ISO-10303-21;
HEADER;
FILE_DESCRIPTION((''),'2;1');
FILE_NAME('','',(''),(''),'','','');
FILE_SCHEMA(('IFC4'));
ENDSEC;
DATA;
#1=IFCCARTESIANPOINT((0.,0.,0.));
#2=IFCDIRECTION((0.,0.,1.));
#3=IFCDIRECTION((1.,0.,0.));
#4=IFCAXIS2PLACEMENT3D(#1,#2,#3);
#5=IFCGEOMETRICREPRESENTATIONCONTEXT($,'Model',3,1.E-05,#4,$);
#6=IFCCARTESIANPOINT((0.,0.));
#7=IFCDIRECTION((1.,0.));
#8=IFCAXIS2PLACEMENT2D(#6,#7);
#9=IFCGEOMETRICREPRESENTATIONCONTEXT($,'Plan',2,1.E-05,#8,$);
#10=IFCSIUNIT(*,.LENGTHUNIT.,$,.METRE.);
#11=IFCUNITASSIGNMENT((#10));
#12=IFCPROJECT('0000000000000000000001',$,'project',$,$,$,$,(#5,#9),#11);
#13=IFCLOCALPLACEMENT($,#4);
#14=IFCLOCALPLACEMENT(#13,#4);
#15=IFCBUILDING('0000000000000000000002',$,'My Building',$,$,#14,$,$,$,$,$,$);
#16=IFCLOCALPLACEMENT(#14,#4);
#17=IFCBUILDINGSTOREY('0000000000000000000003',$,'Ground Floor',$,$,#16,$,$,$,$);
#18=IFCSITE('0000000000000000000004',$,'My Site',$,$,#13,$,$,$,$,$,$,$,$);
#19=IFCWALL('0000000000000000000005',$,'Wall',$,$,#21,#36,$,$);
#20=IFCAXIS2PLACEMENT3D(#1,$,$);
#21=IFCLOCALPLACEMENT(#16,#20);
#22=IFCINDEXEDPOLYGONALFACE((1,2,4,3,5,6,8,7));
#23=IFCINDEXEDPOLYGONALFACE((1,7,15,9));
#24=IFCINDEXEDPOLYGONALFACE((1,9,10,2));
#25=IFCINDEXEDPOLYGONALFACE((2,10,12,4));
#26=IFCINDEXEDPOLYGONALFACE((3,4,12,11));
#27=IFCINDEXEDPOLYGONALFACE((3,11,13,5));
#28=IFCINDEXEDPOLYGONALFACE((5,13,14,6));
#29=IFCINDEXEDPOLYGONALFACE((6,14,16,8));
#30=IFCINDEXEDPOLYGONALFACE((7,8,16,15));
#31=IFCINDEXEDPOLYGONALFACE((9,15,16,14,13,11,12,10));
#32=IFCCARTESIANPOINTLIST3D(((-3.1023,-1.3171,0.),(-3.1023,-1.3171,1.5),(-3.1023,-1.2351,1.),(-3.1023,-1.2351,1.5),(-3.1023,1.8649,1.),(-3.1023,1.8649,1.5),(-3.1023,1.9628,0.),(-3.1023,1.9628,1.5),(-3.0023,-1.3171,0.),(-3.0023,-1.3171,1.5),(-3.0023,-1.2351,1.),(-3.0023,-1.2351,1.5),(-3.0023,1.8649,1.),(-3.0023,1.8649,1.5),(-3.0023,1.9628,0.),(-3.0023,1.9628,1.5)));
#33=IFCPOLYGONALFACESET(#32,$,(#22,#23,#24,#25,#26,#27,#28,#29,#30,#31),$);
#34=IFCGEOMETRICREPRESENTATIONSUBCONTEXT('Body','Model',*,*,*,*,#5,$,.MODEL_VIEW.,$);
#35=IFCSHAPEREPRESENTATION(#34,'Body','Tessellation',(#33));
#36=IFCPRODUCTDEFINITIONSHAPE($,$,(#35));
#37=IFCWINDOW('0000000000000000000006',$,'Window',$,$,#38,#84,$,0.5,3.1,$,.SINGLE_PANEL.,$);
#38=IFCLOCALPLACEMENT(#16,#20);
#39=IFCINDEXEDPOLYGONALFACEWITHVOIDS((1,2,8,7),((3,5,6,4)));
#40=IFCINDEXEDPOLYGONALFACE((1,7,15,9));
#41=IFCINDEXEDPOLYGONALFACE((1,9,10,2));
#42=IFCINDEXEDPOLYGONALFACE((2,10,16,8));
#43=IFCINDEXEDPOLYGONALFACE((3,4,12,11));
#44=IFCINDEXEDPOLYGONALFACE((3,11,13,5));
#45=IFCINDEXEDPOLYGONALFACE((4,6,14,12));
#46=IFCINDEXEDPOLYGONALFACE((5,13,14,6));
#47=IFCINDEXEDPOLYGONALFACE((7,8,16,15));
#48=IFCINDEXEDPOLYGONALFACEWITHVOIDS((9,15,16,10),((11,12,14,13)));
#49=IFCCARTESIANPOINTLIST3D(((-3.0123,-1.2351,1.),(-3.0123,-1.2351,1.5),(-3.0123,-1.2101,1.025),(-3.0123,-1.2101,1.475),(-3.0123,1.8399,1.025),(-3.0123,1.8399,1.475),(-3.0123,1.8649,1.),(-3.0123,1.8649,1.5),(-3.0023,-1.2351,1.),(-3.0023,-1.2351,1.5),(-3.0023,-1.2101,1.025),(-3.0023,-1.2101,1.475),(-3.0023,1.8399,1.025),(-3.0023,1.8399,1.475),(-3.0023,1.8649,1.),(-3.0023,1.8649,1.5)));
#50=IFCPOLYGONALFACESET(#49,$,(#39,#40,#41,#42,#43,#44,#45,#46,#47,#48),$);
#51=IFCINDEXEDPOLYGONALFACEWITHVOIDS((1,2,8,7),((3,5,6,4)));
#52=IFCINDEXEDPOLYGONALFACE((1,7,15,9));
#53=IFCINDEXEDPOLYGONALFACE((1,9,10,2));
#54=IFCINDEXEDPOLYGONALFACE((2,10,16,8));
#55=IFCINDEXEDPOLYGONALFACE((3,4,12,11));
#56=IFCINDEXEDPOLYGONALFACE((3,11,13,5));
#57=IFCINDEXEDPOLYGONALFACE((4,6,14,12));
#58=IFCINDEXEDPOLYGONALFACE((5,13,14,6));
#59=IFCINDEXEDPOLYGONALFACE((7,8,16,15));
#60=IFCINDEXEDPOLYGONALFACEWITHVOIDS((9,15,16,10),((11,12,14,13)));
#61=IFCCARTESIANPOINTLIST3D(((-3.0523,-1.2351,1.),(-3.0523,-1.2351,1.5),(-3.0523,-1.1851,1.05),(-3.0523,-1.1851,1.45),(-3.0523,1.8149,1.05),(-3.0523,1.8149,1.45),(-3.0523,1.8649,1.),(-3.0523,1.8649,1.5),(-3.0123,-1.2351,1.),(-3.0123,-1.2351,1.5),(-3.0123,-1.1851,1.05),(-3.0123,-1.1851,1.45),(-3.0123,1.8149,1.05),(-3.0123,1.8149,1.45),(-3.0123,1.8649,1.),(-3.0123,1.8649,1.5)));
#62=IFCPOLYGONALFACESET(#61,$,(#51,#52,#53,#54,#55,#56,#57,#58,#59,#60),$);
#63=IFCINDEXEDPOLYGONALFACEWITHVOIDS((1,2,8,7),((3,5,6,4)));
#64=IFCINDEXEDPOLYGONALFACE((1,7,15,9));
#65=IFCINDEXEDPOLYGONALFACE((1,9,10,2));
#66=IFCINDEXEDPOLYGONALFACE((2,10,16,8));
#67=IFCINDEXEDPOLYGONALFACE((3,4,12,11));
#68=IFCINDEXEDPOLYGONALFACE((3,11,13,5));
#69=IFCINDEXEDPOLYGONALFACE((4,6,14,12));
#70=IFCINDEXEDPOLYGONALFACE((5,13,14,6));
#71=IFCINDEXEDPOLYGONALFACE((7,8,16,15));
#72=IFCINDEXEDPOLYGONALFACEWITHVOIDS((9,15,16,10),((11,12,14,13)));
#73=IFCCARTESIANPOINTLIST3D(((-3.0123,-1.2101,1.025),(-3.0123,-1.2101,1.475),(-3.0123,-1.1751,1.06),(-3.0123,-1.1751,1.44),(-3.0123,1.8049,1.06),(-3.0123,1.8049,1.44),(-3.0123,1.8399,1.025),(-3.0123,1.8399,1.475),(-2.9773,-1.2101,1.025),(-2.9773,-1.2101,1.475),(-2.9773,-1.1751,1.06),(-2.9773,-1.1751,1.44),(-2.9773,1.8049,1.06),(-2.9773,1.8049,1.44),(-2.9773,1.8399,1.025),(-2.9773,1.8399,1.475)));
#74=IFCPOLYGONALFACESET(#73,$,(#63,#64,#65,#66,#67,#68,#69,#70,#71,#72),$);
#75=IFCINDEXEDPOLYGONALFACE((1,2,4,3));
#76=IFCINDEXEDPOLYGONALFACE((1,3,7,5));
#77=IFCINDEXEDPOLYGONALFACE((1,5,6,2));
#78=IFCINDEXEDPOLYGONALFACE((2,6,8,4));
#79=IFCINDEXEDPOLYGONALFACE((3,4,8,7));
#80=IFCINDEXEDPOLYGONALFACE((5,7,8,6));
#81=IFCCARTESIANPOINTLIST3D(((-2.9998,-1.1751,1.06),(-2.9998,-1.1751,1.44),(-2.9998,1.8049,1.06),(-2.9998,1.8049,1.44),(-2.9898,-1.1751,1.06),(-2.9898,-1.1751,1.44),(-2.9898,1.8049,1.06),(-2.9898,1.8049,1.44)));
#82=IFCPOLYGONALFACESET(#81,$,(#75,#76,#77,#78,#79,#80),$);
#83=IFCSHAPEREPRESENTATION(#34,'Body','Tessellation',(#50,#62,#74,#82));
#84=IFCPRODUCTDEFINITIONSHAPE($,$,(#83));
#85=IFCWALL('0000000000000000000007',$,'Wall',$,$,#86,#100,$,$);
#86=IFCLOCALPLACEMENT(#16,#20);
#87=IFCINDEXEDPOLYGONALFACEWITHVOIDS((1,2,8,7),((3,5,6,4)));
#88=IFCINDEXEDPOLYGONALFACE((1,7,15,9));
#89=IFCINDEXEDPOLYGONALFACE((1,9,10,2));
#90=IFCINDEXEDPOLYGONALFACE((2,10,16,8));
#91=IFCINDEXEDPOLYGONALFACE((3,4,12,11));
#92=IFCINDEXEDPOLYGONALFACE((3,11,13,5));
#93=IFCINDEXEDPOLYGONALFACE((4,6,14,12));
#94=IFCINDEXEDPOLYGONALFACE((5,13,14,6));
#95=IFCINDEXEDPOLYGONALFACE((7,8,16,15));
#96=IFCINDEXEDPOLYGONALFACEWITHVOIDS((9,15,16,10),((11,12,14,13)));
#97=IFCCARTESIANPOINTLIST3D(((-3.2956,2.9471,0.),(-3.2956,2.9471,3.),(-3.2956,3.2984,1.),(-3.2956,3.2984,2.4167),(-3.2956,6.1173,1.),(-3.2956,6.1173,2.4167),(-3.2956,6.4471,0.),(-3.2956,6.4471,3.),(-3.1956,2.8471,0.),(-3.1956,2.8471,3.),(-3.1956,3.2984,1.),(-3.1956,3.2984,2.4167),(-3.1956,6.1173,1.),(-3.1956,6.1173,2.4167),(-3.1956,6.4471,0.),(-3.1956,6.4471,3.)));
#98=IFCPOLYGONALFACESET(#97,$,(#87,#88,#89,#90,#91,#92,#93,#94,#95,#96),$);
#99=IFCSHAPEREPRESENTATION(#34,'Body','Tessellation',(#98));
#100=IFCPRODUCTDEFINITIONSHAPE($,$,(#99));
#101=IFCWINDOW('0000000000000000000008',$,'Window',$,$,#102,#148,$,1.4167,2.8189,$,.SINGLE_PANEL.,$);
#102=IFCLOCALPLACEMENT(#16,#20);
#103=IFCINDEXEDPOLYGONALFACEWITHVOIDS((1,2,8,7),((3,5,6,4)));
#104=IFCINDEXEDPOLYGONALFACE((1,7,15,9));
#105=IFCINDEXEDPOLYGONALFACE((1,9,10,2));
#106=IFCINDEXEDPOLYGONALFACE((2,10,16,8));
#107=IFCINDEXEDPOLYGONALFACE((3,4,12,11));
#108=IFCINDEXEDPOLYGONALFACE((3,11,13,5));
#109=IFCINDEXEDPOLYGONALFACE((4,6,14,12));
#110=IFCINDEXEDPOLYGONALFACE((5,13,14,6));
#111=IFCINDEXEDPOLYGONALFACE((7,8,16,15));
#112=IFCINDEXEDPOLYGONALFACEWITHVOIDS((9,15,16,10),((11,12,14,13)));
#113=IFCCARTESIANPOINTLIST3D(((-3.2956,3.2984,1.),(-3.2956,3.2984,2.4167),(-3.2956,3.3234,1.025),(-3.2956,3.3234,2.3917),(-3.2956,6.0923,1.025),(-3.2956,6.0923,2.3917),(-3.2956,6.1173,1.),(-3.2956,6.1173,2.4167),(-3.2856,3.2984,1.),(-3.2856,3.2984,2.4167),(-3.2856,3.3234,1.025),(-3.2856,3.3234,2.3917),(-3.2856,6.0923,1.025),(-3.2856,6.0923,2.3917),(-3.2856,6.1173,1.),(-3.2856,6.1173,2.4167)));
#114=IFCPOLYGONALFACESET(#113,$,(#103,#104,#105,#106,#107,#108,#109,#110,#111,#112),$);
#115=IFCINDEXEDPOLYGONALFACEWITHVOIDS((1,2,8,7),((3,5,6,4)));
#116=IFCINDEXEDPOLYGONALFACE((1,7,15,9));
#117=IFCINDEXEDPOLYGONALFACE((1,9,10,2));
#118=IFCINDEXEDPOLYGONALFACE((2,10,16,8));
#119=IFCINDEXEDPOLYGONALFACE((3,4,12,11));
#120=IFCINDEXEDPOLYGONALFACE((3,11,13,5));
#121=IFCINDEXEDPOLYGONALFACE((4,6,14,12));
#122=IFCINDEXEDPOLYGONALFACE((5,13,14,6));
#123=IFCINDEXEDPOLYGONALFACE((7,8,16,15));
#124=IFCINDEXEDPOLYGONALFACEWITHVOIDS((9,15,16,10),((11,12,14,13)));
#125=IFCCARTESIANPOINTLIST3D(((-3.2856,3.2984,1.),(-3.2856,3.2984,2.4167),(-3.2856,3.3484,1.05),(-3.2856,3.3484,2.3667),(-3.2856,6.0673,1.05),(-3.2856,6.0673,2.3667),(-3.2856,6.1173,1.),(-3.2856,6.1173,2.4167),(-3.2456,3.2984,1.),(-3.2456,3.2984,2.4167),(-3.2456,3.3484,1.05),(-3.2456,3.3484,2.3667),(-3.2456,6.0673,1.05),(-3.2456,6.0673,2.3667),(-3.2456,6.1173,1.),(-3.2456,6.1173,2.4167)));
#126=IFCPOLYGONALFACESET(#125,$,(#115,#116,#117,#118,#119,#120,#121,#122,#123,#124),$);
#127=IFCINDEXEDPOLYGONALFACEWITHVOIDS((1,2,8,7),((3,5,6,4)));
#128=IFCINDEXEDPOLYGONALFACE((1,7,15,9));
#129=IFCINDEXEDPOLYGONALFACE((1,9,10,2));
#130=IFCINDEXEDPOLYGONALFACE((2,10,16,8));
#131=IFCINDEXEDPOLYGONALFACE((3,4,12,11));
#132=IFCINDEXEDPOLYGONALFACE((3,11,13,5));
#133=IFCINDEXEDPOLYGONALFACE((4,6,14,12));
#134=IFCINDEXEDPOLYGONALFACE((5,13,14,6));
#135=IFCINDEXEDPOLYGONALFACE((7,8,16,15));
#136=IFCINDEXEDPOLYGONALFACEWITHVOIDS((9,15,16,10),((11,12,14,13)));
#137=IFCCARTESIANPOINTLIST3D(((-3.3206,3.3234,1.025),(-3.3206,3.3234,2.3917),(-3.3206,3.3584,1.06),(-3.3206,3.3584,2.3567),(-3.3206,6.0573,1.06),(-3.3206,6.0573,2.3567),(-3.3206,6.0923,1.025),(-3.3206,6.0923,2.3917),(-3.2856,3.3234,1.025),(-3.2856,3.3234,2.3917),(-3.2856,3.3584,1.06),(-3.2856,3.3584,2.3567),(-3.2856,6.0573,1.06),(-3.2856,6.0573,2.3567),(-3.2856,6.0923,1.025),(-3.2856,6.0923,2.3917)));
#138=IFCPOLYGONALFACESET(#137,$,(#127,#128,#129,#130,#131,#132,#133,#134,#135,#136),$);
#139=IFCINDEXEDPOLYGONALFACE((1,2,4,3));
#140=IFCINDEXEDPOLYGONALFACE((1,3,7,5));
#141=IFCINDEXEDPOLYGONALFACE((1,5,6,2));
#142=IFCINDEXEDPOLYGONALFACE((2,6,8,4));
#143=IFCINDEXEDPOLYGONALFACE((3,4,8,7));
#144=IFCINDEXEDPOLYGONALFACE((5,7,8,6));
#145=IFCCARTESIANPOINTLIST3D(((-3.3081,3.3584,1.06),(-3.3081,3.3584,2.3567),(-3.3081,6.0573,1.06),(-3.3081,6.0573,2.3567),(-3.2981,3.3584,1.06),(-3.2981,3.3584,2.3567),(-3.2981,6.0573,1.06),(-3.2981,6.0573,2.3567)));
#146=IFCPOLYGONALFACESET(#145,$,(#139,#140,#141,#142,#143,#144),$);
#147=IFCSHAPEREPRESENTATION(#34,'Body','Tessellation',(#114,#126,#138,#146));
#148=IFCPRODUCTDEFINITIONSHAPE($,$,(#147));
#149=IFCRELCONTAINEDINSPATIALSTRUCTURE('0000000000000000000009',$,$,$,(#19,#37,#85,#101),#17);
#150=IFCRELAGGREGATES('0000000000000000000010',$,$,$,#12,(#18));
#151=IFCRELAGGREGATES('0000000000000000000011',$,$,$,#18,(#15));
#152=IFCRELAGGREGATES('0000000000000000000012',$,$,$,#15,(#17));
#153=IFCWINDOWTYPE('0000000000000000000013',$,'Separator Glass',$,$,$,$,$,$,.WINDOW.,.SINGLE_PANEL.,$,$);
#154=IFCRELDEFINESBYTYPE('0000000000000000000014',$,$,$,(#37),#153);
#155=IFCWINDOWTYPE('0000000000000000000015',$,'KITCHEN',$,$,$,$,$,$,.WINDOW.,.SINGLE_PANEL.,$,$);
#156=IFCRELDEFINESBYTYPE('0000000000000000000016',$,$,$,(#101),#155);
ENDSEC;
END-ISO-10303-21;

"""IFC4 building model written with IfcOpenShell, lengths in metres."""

from ifc_helpers import new_model, entity, si_unit, frame, origin_with_axes, origin_2d_with_axis, place, context, subcontext, project, spatial, line, indexed_curve, outline, extrude, shape, source, transform, mapped, type_object, type_shapes, element, fill, save


model = new_model("IFC4")

# Units and contexts
model_context = context("Model", 3, precision=1e-05, world=origin_with_axes())
plan_context = context("Plan", 2, precision=1e-05, world=origin_2d_with_axis())
body_context_1 = subcontext(model_context, "Body", "Model", "MODEL_VIEW")
body_context_2 = subcontext(plan_context, "Body", "Plan", "PLAN_VIEW")
ifc_project = project(units=[si_unit("LENGTHUNIT", "METRE")], contexts=[model_context, plan_context])

# Site, building, storey
site_placement = place(None, origin_with_axes())
site = spatial("IfcSite", under=ifc_project, at=site_placement, Name="My Site")
building_placement = place(site_placement, origin_with_axes())
building = spatial("IfcBuilding", under=site, at=building_placement, Name="My Building")
storey_placement = place(building_placement, origin_with_axes())
storey = spatial("IfcBuildingStorey", under=building, at=storey_placement, Name="Ground Floor")

# Walls, openings, windows
wall_1_placement = place(storey_placement, frame((-3.0023, -1.3171, 0.0), z_axis=(0.0, 0.0, 1.0), x_axis=(0.0, 1.0, 0.0)))
wall_1 = element("IfcWall", 1, at=wall_1_placement, inside=storey, Name="Wall", context=body_context_1, shape_type="SweptSolid", body=[
    extrude(outline(indexed_curve([(0.0, 0.0), (0.0, 0.1), (3.2798, 0.1), (3.2798, 0.0)], segments=[line(1, 2, 3, 4, 1)])), origin_with_axes(), (0.0, 0.0, 1.0), 1.5),
])
shared_shape_1 = source(origin_with_axes(), body_context_1, "Body", "SweptSolid", [
    extrude(outline(indexed_curve([(0.0, 0.0), (3.1, 0.0), (3.1, 0.5), (0.0, 0.5)], segments=[line(1, 2, 3, 4, 1)])), frame((0.0, -0.6, 0.0), z_axis=(0.0, -1.0, 0.0), x_axis=(1.0, 0.0, 0.0)), (0.0, 0.0, -1.0), 1.2),
])
opening_1_placement = place(wall_1_placement, frame((3.1819, 0.1, 1.0), z_axis=(0.0, 0.0, 1.0), x_axis=(-1.0, 0.0, 0.0)))
opening_1 = element("IfcOpeningElement", 2, at=opening_1_placement, cuts=wall_1, PredefinedType="OPENING", context=body_context_1, shape_type="MappedRepresentation", body=[
    mapped(shared_shape_1, transform((0.0, 0.0, 0.0), x_axis=(1.0, 0.0, 0.0), y_axis=(0.0, 1.0, 0.0), z_axis=(0.0, 0.0, 1.0), scale=1.0)),
])
window_type_1 = type_object("IfcWindowType", Name="Separator Glass", PartitioningType="SINGLE_PANEL", PredefinedType="WINDOW")
shared_shape_2 = source(origin_with_axes(), body_context_1, "Body", "SweptSolid", [
    extrude(outline(indexed_curve([(0.0, 0.0), (3.1, 0.0), (3.1, 0.5), (0.0, 0.5)], segments=[line(1, 2, 3, 4, 1)]), holes=[indexed_curve([(0.025, 0.025), (3.075, 0.025), (3.075, 0.475), (0.025, 0.475)], segments=[line(1, 2, 3, 4, 1)])]), frame((0.0, 0.09, 0.0), z_axis=(0.0, -1.0, 0.0), x_axis=(1.0, 0.0, 0.0)), (0.0, 0.0, -1.0), 0.01),
    extrude(outline(indexed_curve([(0.0, 0.0), (3.1, 0.0), (3.1, 0.5), (0.0, 0.5)], segments=[line(1, 2, 3, 4, 1)]), holes=[indexed_curve([(0.05, 0.05), (3.05, 0.05), (3.05, 0.45), (0.05, 0.45)], segments=[line(1, 2, 3, 4, 1)])]), frame((0.0, 0.05, 0.0), z_axis=(0.0, -1.0, 0.0), x_axis=(1.0, 0.0, 0.0)), (0.0, 0.0, -1.0), 0.04),
    extrude(outline(indexed_curve([(0.0, 0.0), (3.05, 0.0), (3.05, 0.45), (0.0, 0.45)], segments=[line(1, 2, 3, 4, 1)]), holes=[indexed_curve([(0.035, 0.035), (3.015, 0.035), (3.015, 0.415), (0.035, 0.415)], segments=[line(1, 2, 3, 4, 1)])]), frame((0.025, 0.09, 0.025), z_axis=(0.0, -1.0, 0.0), x_axis=(1.0, 0.0, 0.0)), (0.0, 0.0, -1.0), 0.035),
    extrude(outline(indexed_curve([(0.035, 0.035), (3.015, 0.035), (3.015, 0.415), (0.035, 0.415)], segments=[line(1, 2, 3, 4, 1)])), frame((0.025, 0.1025, 0.025), z_axis=(0.0, -1.0, 0.0), x_axis=(1.0, 0.0, 0.0)), (0.0, 0.0, -1.0), 0.01),
])
shared_shape_3 = source(origin_with_axes(), body_context_2, "Body", "Curve2D", [
    entity("IfcIndexedPolyCurve", entity("IfcCartesianPointList2D", [[0.05, 0.05], [3.05, 0.05]])),
    entity("IfcIndexedPolyCurve", entity("IfcCartesianPointList2D", [[0.0, 0.1], [0.025, 0.1], [0.025, 0.09], [0.05, 0.09], [0.05, 0.05], [0.0, 0.05]]), [entity("IfcLineIndex", [1, 2, 3, 4, 5, 6, 1])]),
    entity("IfcIndexedPolyCurve", entity("IfcCartesianPointList2D", [[3.1, 0.1], [3.075, 0.1], [3.075, 0.09], [3.05, 0.09], [3.05, 0.05], [3.1, 0.05]]), [entity("IfcLineIndex", [1, 2, 3, 4, 5, 6, 1])]),
    entity("IfcIndexedPolyCurve", entity("IfcCartesianPointList2D", [[0.025, 0.09], [0.06, 0.09], [0.06, 0.125], [0.025, 0.125]]), [entity("IfcLineIndex", [1, 2, 3, 4, 1])]),
    entity("IfcIndexedPolyCurve", entity("IfcCartesianPointList2D", [[3.075, 0.09], [3.04, 0.09], [3.04, 0.125], [3.075, 0.125]]), [entity("IfcLineIndex", [1, 2, 3, 4, 1])]),
    entity("IfcIndexedPolyCurve", entity("IfcCartesianPointList2D", [[0.06, 0.09], [3.04, 0.09]])),
    entity("IfcIndexedPolyCurve", entity("IfcCartesianPointList2D", [[0.06, 0.125], [3.04, 0.125]])),
    entity("IfcIndexedPolyCurve", entity("IfcCartesianPointList2D", [[0.06, 0.1075], [3.04, 0.1075]])),
])
type_shapes(window_type_1, [shared_shape_2, shared_shape_3])
window_1_placement = place(opening_1_placement, frame((0.0, 0.0, 0.0), z_axis=(0.0, 0.0, 1.0), x_axis=(1.0, 0.0, 0.0)))
window_1 = element("IfcWindow", 3, at=window_1_placement, inside=storey, type_object=window_type_1, Name="Window", OverallHeight=0.5, OverallWidth=3.1, PartitioningType="SINGLE_PANEL", shapes=[
    shape(body_context_1, "Body", "MappedRepresentation", [mapped(shared_shape_2, transform((0.0, 0.0, 0.0), x_axis=(1.0, 0.0, 0.0), y_axis=(0.0, 1.0, 0.0), z_axis=(0.0, 0.0, 1.0), scale=1.0))]),
    shape(body_context_2, "Body", "MappedRepresentation", [mapped(shared_shape_3, transform((0.0, 0.0, 0.0), x_axis=(1.0, 0.0, 0.0), y_axis=(0.0, 1.0, 0.0), z_axis=(0.0, 0.0, 1.0), scale=1.0))]),
])
fill(opening_1, window_1)
wall_2_placement = place(storey_placement, frame((-3.2956, 6.4471, 0.0), z_axis=(0.0, 0.0, 1.0), x_axis=(0.0, -1.0, 0.0)))
wall_2 = element("IfcWall", 4, at=wall_2_placement, inside=storey, Name="Wall", context=body_context_1, shape_type="SweptSolid", body=[
    extrude(outline(indexed_curve([(0.0, 0.0), (0.0, 0.1), (3.6, 0.1), (3.5, 0.0)], segments=[line(1, 2, 3, 4, 1)])), origin_with_axes(), (0.0, 0.0, 1.0), 3.0),
])
shared_shape_4 = source(origin_with_axes(), body_context_1, "Body", "SweptSolid", [
    extrude(outline(indexed_curve([(0.0, 0.0), (2.8189, 0.0), (2.8189, 1.4167), (0.0, 1.4167)], segments=[line(1, 2, 3, 4, 1)])), frame((0.0, -0.6, 0.0), z_axis=(0.0, -1.0, 0.0), x_axis=(1.0, 0.0, 0.0)), (0.0, 0.0, -1.0), 1.2),
])
opening_2_placement = place(wall_2_placement, frame((3.1487, 0.1, 1.0), z_axis=(0.0, 0.0, 1.0), x_axis=(-1.0, 0.0, 0.0)))
opening_2 = element("IfcOpeningElement", 5, at=opening_2_placement, cuts=wall_2, PredefinedType="OPENING", context=body_context_1, shape_type="MappedRepresentation", body=[
    mapped(shared_shape_4, transform((0.0, 0.0, 0.0), x_axis=(1.0, 0.0, 0.0), y_axis=(0.0, 1.0, 0.0), z_axis=(0.0, 0.0, 1.0), scale=1.0)),
])
window_type_2 = type_object("IfcWindowType", Name="KITCHEN", PartitioningType="SINGLE_PANEL", PredefinedType="WINDOW")
shared_shape_5 = source(origin_with_axes(), body_context_1, "Body", "SweptSolid", [
    extrude(outline(indexed_curve([(0.0, 0.0), (2.8189, 0.0), (2.8189, 1.4167), (0.0, 1.4167)], segments=[line(1, 2, 3, 4, 1)]), holes=[indexed_curve([(0.025, 0.025), (2.7939, 0.025), (2.7939, 1.3917), (0.025, 1.3917)], segments=[line(1, 2, 3, 4, 1)])]), frame((0.0, 0.09, 0.0), z_axis=(0.0, -1.0, 0.0), x_axis=(1.0, 0.0, 0.0)), (0.0, 0.0, -1.0), 0.01),
    extrude(outline(indexed_curve([(0.0, 0.0), (2.8189, 0.0), (2.8189, 1.4167), (0.0, 1.4167)], segments=[line(1, 2, 3, 4, 1)]), holes=[indexed_curve([(0.05, 0.05), (2.7689, 0.05), (2.7689, 1.3667), (0.05, 1.3667)], segments=[line(1, 2, 3, 4, 1)])]), frame((0.0, 0.05, 0.0), z_axis=(0.0, -1.0, 0.0), x_axis=(1.0, 0.0, 0.0)), (0.0, 0.0, -1.0), 0.04),
    extrude(outline(indexed_curve([(0.0, 0.0), (2.7689, 0.0), (2.7689, 1.3667), (0.0, 1.3667)], segments=[line(1, 2, 3, 4, 1)]), holes=[indexed_curve([(0.035, 0.035), (2.7339, 0.035), (2.7339, 1.3317), (0.035, 1.3317)], segments=[line(1, 2, 3, 4, 1)])]), frame((0.025, 0.09, 0.025), z_axis=(0.0, -1.0, 0.0), x_axis=(1.0, 0.0, 0.0)), (0.0, 0.0, -1.0), 0.035),
    extrude(outline(indexed_curve([(0.035, 0.035), (2.7339, 0.035), (2.7339, 1.3317), (0.035, 1.3317)], segments=[line(1, 2, 3, 4, 1)])), frame((0.025, 0.1025, 0.025), z_axis=(0.0, -1.0, 0.0), x_axis=(1.0, 0.0, 0.0)), (0.0, 0.0, -1.0), 0.01),
])
shared_shape_6 = source(origin_with_axes(), body_context_2, "Body", "Curve2D", [
    entity("IfcIndexedPolyCurve", entity("IfcCartesianPointList2D", [[0.05, 0.05], [2.7689, 0.05]])),
    entity("IfcIndexedPolyCurve", entity("IfcCartesianPointList2D", [[0.0, 0.1], [0.025, 0.1], [0.025, 0.09], [0.05, 0.09], [0.05, 0.05], [0.0, 0.05]]), [entity("IfcLineIndex", [1, 2, 3, 4, 5, 6, 1])]),
    entity("IfcIndexedPolyCurve", entity("IfcCartesianPointList2D", [[2.8189, 0.1], [2.7939, 0.1], [2.7939, 0.09], [2.7689, 0.09], [2.7689, 0.05], [2.8189, 0.05]]), [entity("IfcLineIndex", [1, 2, 3, 4, 5, 6, 1])]),
    entity("IfcIndexedPolyCurve", entity("IfcCartesianPointList2D", [[0.025, 0.09], [0.06, 0.09], [0.06, 0.125], [0.025, 0.125]]), [entity("IfcLineIndex", [1, 2, 3, 4, 1])]),
    entity("IfcIndexedPolyCurve", entity("IfcCartesianPointList2D", [[2.7939, 0.09], [2.7589, 0.09], [2.7589, 0.125], [2.7939, 0.125]]), [entity("IfcLineIndex", [1, 2, 3, 4, 1])]),
    entity("IfcIndexedPolyCurve", entity("IfcCartesianPointList2D", [[0.06, 0.09], [2.7589, 0.09]])),
    entity("IfcIndexedPolyCurve", entity("IfcCartesianPointList2D", [[0.06, 0.125], [2.7589, 0.125]])),
    entity("IfcIndexedPolyCurve", entity("IfcCartesianPointList2D", [[0.06, 0.1075], [2.7589, 0.1075]])),
])
type_shapes(window_type_2, [shared_shape_5, shared_shape_6])
window_2_placement = place(opening_2_placement, frame((0.0, 0.0, 0.0), z_axis=(0.0, 0.0, 1.0), x_axis=(1.0, 0.0, 0.0)))
window_2 = element("IfcWindow", 6, at=window_2_placement, inside=storey, type_object=window_type_2, Name="Window", OverallHeight=1.4167, OverallWidth=2.8189, PartitioningType="SINGLE_PANEL", shapes=[
    shape(body_context_1, "Body", "MappedRepresentation", [mapped(shared_shape_5, transform((0.0, 0.0, 0.0), x_axis=(1.0, 0.0, 0.0), y_axis=(0.0, 1.0, 0.0), z_axis=(0.0, 0.0, 1.0), scale=1.0))]),
    shape(body_context_2, "Body", "MappedRepresentation", [mapped(shared_shape_6, transform((0.0, 0.0, 0.0), x_axis=(1.0, 0.0, 0.0), y_axis=(0.0, 1.0, 0.0), z_axis=(0.0, 0.0, 1.0), scale=1.0))]),
])
fill(opening_2, window_2)

save(model, "model.ifc")
